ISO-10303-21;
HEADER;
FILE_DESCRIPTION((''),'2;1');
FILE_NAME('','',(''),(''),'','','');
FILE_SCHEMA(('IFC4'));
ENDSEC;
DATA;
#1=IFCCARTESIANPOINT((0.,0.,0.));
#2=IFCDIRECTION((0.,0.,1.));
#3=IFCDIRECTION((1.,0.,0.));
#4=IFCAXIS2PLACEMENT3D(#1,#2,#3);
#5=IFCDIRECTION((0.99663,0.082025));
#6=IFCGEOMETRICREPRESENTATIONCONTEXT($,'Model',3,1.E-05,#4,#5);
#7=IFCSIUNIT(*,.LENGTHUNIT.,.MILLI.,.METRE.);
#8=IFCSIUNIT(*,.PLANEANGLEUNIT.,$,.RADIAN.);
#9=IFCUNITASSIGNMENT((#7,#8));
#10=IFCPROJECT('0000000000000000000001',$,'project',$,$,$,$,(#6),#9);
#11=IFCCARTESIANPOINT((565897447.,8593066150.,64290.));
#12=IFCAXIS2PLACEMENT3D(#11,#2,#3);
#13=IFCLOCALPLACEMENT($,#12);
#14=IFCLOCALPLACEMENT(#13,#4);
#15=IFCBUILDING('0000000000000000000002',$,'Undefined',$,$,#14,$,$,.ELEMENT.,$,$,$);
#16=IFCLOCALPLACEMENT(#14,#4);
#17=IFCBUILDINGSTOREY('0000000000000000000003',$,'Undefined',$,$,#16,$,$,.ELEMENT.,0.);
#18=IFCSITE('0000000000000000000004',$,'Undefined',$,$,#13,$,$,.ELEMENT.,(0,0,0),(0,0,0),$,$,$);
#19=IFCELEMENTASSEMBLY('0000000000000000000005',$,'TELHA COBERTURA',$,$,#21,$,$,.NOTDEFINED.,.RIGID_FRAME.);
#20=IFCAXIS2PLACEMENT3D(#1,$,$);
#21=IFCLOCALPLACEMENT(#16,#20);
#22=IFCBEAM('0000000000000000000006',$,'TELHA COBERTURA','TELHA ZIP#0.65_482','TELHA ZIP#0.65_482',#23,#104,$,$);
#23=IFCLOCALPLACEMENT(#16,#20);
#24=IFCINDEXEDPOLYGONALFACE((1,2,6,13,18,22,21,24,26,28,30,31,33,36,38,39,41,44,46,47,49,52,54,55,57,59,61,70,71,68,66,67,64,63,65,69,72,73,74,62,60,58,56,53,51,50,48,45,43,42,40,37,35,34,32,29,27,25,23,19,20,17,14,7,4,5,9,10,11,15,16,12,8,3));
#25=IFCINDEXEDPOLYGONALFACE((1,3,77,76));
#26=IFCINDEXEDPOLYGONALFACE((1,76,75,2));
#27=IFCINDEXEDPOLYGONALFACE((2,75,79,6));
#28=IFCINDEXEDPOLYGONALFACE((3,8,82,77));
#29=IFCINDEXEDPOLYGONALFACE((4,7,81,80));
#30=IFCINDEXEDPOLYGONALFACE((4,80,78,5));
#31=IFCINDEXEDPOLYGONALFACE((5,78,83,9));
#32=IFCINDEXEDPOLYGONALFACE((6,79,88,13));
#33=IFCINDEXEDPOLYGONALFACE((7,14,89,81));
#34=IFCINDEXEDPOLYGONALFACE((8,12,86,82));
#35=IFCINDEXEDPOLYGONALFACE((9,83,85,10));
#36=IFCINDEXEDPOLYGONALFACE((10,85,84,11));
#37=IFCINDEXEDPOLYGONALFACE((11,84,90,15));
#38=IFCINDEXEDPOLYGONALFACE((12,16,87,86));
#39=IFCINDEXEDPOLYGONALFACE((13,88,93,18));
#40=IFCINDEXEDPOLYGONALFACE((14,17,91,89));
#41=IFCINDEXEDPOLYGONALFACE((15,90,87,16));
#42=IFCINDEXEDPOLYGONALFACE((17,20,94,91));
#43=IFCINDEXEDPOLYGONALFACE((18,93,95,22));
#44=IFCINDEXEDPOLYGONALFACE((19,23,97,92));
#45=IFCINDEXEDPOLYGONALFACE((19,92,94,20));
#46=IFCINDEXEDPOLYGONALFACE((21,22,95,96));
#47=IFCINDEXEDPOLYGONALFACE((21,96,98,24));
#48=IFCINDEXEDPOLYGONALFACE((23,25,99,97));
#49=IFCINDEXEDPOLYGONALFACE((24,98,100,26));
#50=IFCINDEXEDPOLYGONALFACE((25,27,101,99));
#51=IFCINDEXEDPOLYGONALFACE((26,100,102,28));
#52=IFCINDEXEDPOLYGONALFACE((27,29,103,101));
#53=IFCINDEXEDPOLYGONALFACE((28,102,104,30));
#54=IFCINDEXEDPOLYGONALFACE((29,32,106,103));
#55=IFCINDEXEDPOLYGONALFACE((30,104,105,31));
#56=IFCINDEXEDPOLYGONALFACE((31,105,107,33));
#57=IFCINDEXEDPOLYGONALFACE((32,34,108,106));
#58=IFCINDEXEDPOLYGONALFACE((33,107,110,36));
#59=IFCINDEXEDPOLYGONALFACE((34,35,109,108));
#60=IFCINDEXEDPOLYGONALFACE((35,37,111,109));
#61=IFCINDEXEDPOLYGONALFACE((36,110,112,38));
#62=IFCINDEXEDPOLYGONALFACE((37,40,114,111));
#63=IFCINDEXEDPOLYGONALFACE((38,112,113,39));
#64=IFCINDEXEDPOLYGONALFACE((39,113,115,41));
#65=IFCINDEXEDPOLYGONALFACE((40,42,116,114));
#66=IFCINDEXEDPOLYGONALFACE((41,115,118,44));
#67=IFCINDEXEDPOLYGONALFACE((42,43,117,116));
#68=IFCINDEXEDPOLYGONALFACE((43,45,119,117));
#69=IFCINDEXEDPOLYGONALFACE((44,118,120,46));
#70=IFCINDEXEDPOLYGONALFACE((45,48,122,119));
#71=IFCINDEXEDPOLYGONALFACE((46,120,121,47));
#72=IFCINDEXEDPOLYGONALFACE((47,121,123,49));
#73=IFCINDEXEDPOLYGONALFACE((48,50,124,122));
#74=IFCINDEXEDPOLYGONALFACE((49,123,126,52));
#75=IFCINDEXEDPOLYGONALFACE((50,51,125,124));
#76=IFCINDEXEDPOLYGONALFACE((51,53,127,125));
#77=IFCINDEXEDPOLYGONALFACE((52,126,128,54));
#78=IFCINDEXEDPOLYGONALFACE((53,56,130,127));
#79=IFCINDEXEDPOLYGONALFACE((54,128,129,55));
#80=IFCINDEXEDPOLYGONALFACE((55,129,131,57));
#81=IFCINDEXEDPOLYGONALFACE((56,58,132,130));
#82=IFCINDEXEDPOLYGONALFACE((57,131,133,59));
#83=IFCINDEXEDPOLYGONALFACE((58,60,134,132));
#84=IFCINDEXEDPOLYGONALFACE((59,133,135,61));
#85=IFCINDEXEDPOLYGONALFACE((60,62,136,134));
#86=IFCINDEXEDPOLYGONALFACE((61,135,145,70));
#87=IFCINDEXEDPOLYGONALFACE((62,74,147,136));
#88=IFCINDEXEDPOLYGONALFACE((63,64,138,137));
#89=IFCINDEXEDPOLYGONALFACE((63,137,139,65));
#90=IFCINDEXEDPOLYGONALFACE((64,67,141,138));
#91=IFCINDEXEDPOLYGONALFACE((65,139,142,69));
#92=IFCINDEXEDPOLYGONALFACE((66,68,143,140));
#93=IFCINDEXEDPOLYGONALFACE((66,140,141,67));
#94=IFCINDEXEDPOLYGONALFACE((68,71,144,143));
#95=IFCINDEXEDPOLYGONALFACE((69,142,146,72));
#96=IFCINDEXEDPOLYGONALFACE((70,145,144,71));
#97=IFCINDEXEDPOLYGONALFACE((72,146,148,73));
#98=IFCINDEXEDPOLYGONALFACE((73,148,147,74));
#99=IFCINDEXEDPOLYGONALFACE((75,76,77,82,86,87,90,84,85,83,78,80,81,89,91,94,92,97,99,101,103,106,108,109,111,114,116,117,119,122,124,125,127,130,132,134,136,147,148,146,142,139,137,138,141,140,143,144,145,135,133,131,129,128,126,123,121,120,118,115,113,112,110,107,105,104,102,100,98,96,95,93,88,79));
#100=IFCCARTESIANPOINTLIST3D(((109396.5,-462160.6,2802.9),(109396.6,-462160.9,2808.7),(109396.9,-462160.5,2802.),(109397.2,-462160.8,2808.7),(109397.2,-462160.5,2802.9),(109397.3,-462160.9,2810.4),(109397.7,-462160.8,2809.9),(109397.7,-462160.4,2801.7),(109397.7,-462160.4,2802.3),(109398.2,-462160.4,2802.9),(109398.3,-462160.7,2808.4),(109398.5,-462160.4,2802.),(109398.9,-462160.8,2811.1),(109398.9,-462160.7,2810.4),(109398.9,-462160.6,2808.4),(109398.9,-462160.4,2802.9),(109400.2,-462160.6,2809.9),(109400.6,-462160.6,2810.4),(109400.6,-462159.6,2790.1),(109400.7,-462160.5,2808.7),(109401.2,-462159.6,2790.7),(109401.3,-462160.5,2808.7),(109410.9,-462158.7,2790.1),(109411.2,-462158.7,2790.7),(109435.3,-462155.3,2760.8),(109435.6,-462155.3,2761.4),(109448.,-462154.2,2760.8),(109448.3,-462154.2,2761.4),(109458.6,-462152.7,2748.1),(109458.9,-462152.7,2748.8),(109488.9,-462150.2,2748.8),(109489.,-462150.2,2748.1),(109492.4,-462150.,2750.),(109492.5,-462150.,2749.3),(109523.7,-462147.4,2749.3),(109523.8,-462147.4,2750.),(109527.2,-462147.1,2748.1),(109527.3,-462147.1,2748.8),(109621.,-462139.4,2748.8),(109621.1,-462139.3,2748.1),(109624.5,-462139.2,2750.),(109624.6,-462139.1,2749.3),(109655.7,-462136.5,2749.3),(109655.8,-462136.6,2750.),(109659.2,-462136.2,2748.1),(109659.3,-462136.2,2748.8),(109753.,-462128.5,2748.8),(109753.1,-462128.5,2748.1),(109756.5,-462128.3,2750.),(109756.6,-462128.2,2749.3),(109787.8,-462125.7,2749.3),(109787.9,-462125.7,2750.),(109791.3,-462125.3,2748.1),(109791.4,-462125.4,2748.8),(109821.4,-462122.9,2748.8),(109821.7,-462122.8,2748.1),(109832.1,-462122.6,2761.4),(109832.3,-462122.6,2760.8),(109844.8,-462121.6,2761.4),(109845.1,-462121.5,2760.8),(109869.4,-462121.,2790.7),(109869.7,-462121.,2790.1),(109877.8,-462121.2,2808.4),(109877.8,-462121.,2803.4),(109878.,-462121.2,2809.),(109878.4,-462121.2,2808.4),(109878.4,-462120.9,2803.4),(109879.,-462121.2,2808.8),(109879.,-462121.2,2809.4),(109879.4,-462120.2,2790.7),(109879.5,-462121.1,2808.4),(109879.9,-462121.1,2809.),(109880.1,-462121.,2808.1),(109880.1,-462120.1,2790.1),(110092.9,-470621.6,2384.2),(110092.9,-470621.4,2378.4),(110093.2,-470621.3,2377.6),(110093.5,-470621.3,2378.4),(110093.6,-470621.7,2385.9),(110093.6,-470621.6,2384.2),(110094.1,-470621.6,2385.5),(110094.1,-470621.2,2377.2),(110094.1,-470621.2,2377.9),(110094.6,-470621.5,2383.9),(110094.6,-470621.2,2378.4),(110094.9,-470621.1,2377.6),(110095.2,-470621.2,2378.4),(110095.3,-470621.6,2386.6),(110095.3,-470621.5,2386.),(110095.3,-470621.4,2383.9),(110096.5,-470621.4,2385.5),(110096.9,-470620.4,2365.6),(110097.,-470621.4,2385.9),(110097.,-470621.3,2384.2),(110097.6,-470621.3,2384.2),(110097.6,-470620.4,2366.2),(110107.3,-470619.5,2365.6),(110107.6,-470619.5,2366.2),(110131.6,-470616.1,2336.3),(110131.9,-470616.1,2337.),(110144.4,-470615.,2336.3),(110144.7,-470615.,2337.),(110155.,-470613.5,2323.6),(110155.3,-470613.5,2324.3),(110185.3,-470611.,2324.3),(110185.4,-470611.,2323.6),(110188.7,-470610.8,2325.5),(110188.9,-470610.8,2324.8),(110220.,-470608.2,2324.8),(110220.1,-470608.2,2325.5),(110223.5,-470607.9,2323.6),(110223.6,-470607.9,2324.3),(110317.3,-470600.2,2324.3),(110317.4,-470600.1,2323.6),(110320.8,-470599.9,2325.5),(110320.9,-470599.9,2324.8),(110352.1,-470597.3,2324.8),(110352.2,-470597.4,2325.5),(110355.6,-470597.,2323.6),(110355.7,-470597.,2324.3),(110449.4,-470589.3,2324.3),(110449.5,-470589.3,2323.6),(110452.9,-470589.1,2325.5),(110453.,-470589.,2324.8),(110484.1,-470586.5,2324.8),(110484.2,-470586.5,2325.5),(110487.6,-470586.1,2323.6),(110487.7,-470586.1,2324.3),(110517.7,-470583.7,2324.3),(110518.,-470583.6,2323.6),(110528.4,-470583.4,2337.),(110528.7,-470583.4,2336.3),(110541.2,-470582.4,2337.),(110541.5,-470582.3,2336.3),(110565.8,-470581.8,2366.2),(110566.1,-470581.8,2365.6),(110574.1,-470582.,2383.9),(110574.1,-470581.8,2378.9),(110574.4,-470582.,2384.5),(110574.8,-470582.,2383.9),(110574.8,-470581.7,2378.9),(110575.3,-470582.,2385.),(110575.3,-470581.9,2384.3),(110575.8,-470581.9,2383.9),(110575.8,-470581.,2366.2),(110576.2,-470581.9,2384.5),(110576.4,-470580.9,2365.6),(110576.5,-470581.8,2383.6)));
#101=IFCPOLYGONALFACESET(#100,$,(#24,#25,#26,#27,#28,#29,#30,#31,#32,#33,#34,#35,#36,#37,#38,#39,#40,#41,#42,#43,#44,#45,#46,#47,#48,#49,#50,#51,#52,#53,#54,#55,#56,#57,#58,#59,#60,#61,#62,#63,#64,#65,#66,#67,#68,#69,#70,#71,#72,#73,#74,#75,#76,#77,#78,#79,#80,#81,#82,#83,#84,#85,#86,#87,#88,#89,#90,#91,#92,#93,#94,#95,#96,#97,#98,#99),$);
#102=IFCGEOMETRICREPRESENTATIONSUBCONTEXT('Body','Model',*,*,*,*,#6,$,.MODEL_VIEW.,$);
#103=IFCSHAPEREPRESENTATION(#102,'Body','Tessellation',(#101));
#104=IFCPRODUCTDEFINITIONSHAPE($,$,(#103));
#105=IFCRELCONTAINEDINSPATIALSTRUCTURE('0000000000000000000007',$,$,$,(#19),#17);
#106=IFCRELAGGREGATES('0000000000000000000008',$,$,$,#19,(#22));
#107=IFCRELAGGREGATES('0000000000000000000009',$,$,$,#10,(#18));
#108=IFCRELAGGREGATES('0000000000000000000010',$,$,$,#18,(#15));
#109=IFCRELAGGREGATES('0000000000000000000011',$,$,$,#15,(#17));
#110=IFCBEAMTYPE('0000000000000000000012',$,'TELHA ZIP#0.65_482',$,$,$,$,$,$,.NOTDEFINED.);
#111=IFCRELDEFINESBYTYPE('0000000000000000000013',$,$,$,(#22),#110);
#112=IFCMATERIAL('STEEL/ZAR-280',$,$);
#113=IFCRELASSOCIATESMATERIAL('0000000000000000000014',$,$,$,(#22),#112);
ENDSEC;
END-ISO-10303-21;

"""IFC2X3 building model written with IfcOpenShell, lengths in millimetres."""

from ifc_helpers import new_model, si_unit, direction, frame, origin_with_axes, place, context, subcontext, project, spatial, polyline, outline, extrude, material, type_object, element, aggregate, save


model = new_model("IFC2X3")

# Units and contexts
model_context = context("Model", 3, precision=1e-05, world=origin_with_axes(), true_north=direction((0.99663, 0.082025)))
body_context = subcontext(model_context, "Body", "Model", "MODEL_VIEW")
ifc_project = project(units=[si_unit("LENGTHUNIT", "METRE", prefix="MILLI"), si_unit("PLANEANGLEUNIT", "RADIAN")], contexts=[model_context])

# Site, building, storey
site_placement = place(None, frame((565897447.0, 8593066150.0, 64290.0), z_axis=(0.0, 0.0, 1.0), x_axis=(1.0, 0.0, 0.0)))
site = spatial("IfcSite", under=ifc_project, at=site_placement, Name="Undefined", CompositionType="ELEMENT", RefLatitude=(0, 0, 0), RefLongitude=(0, 0, 0))
building_placement = place(site_placement, origin_with_axes())
building = spatial("IfcBuilding", under=site, at=building_placement, Name="Undefined", CompositionType="ELEMENT")
storey_placement = place(building_placement, origin_with_axes())
storey = spatial("IfcBuildingStorey", under=building, at=storey_placement, Name="Undefined", CompositionType="ELEMENT", Elevation=0.0)

# Element assembly, beam
ifc_material_1 = material(Name="STEEL/ZAR-280")
beam_type_1 = type_object("IfcBeamType", Name="TELHA ZIP#0.65_482", PredefinedType="NOTDEFINED")
assembly_1_placement = place(storey_placement, origin_with_axes())
assembly_1 = element("IfcElementAssembly", 1, at=assembly_1_placement, inside=storey, Name="TELHA COBERTURA", AssemblyPlace="NOTDEFINED", PredefinedType="RIGID_FRAME")
beam_1_placement = place(assembly_1_placement, frame((110334.6, -470600.3, 2354.8), z_axis=(0.004096, -0.049769, 0.998752), x_axis=(-0.081923, 0.995387, 0.049938)))
beam_1 = element("IfcBeam", 2, at=beam_1_placement, type_object=beam_type_1, material=ifc_material_1, Name="TELHA COBERTURA", Description="TELHA ZIP#0.65_482", ObjectType="TELHA ZIP#0.65_482", context=body_context, shape_type="SweptSolid", body=[
    extrude(outline(polyline([(240.5, 29.7), (241.4, 30.2), (242.4, 29.7), (242.6, 28.9), (242.6, 10.8), (232.2, 10.8), (207.6, -18.5), (194.9, -18.5), (184.2, -31.2), (153.7, -31.2), (150.2, -30.0), (118.9, -30.0), (115.4, -31.2), (21.2, -31.2), (17.7, -30.0), (-13.6, -30.0), (-17.1, -31.2), (-111.3, -31.2), (-114.8, -30.0), (-146.1, -30.0), (-149.6, -31.2), (-180.1, -31.2), (-190.8, -18.5), (-203.6, -18.5), (-228.1, 10.8), (-238.5, 10.8), (-238.5, 29.5), (-239.0, 30.7), (-240.2, 31.2), (-241.4, 30.7), (-241.9, 29.5), (-241.9, 23.6), (-241.4, 23.1), (-240.9, 23.6), (-240.9, 29.1), (-240.2, 29.1), (-240.2, 23.6), (-240.6, 22.8), (-241.4, 22.4), (-242.3, 22.8), (-242.6, 23.6), (-242.6, 29.5), (-241.9, 31.2), (-240.2, 31.9), (-238.5, 31.2), (-237.9, 29.5), (-237.9, 11.4), (-227.8, 11.4), (-203.2, -17.9), (-190.4, -17.9), (-179.8, -30.5), (-149.7, -30.5), (-146.2, -29.4), (-114.7, -29.4), (-111.2, -30.5), (-17.2, -30.5), (-13.7, -29.4), (17.8, -29.4), (21.3, -30.5), (115.3, -30.5), (118.8, -29.4), (150.3, -29.4), (153.8, -30.5), (183.9, -30.5), (194.6, -17.9), (207.4, -17.9), (231.9, 11.4), (241.9, 11.4), (241.9, 29.1), (241.4, 29.5), (240.9, 29.1), (240.9, 24.1), (240.2, 24.1), (240.2, 29.2), (240.5, 29.7)])), frame((8500.0, 0.0, 0.0), z_axis=(-1.0, 0.0, 0.0), x_axis=(0.0, -1.0, 0.0)), (0.0, 0.0, 1.0), 8500.0),
])
aggregate(assembly_1, [beam_1])

save(model, "model.ifc")
